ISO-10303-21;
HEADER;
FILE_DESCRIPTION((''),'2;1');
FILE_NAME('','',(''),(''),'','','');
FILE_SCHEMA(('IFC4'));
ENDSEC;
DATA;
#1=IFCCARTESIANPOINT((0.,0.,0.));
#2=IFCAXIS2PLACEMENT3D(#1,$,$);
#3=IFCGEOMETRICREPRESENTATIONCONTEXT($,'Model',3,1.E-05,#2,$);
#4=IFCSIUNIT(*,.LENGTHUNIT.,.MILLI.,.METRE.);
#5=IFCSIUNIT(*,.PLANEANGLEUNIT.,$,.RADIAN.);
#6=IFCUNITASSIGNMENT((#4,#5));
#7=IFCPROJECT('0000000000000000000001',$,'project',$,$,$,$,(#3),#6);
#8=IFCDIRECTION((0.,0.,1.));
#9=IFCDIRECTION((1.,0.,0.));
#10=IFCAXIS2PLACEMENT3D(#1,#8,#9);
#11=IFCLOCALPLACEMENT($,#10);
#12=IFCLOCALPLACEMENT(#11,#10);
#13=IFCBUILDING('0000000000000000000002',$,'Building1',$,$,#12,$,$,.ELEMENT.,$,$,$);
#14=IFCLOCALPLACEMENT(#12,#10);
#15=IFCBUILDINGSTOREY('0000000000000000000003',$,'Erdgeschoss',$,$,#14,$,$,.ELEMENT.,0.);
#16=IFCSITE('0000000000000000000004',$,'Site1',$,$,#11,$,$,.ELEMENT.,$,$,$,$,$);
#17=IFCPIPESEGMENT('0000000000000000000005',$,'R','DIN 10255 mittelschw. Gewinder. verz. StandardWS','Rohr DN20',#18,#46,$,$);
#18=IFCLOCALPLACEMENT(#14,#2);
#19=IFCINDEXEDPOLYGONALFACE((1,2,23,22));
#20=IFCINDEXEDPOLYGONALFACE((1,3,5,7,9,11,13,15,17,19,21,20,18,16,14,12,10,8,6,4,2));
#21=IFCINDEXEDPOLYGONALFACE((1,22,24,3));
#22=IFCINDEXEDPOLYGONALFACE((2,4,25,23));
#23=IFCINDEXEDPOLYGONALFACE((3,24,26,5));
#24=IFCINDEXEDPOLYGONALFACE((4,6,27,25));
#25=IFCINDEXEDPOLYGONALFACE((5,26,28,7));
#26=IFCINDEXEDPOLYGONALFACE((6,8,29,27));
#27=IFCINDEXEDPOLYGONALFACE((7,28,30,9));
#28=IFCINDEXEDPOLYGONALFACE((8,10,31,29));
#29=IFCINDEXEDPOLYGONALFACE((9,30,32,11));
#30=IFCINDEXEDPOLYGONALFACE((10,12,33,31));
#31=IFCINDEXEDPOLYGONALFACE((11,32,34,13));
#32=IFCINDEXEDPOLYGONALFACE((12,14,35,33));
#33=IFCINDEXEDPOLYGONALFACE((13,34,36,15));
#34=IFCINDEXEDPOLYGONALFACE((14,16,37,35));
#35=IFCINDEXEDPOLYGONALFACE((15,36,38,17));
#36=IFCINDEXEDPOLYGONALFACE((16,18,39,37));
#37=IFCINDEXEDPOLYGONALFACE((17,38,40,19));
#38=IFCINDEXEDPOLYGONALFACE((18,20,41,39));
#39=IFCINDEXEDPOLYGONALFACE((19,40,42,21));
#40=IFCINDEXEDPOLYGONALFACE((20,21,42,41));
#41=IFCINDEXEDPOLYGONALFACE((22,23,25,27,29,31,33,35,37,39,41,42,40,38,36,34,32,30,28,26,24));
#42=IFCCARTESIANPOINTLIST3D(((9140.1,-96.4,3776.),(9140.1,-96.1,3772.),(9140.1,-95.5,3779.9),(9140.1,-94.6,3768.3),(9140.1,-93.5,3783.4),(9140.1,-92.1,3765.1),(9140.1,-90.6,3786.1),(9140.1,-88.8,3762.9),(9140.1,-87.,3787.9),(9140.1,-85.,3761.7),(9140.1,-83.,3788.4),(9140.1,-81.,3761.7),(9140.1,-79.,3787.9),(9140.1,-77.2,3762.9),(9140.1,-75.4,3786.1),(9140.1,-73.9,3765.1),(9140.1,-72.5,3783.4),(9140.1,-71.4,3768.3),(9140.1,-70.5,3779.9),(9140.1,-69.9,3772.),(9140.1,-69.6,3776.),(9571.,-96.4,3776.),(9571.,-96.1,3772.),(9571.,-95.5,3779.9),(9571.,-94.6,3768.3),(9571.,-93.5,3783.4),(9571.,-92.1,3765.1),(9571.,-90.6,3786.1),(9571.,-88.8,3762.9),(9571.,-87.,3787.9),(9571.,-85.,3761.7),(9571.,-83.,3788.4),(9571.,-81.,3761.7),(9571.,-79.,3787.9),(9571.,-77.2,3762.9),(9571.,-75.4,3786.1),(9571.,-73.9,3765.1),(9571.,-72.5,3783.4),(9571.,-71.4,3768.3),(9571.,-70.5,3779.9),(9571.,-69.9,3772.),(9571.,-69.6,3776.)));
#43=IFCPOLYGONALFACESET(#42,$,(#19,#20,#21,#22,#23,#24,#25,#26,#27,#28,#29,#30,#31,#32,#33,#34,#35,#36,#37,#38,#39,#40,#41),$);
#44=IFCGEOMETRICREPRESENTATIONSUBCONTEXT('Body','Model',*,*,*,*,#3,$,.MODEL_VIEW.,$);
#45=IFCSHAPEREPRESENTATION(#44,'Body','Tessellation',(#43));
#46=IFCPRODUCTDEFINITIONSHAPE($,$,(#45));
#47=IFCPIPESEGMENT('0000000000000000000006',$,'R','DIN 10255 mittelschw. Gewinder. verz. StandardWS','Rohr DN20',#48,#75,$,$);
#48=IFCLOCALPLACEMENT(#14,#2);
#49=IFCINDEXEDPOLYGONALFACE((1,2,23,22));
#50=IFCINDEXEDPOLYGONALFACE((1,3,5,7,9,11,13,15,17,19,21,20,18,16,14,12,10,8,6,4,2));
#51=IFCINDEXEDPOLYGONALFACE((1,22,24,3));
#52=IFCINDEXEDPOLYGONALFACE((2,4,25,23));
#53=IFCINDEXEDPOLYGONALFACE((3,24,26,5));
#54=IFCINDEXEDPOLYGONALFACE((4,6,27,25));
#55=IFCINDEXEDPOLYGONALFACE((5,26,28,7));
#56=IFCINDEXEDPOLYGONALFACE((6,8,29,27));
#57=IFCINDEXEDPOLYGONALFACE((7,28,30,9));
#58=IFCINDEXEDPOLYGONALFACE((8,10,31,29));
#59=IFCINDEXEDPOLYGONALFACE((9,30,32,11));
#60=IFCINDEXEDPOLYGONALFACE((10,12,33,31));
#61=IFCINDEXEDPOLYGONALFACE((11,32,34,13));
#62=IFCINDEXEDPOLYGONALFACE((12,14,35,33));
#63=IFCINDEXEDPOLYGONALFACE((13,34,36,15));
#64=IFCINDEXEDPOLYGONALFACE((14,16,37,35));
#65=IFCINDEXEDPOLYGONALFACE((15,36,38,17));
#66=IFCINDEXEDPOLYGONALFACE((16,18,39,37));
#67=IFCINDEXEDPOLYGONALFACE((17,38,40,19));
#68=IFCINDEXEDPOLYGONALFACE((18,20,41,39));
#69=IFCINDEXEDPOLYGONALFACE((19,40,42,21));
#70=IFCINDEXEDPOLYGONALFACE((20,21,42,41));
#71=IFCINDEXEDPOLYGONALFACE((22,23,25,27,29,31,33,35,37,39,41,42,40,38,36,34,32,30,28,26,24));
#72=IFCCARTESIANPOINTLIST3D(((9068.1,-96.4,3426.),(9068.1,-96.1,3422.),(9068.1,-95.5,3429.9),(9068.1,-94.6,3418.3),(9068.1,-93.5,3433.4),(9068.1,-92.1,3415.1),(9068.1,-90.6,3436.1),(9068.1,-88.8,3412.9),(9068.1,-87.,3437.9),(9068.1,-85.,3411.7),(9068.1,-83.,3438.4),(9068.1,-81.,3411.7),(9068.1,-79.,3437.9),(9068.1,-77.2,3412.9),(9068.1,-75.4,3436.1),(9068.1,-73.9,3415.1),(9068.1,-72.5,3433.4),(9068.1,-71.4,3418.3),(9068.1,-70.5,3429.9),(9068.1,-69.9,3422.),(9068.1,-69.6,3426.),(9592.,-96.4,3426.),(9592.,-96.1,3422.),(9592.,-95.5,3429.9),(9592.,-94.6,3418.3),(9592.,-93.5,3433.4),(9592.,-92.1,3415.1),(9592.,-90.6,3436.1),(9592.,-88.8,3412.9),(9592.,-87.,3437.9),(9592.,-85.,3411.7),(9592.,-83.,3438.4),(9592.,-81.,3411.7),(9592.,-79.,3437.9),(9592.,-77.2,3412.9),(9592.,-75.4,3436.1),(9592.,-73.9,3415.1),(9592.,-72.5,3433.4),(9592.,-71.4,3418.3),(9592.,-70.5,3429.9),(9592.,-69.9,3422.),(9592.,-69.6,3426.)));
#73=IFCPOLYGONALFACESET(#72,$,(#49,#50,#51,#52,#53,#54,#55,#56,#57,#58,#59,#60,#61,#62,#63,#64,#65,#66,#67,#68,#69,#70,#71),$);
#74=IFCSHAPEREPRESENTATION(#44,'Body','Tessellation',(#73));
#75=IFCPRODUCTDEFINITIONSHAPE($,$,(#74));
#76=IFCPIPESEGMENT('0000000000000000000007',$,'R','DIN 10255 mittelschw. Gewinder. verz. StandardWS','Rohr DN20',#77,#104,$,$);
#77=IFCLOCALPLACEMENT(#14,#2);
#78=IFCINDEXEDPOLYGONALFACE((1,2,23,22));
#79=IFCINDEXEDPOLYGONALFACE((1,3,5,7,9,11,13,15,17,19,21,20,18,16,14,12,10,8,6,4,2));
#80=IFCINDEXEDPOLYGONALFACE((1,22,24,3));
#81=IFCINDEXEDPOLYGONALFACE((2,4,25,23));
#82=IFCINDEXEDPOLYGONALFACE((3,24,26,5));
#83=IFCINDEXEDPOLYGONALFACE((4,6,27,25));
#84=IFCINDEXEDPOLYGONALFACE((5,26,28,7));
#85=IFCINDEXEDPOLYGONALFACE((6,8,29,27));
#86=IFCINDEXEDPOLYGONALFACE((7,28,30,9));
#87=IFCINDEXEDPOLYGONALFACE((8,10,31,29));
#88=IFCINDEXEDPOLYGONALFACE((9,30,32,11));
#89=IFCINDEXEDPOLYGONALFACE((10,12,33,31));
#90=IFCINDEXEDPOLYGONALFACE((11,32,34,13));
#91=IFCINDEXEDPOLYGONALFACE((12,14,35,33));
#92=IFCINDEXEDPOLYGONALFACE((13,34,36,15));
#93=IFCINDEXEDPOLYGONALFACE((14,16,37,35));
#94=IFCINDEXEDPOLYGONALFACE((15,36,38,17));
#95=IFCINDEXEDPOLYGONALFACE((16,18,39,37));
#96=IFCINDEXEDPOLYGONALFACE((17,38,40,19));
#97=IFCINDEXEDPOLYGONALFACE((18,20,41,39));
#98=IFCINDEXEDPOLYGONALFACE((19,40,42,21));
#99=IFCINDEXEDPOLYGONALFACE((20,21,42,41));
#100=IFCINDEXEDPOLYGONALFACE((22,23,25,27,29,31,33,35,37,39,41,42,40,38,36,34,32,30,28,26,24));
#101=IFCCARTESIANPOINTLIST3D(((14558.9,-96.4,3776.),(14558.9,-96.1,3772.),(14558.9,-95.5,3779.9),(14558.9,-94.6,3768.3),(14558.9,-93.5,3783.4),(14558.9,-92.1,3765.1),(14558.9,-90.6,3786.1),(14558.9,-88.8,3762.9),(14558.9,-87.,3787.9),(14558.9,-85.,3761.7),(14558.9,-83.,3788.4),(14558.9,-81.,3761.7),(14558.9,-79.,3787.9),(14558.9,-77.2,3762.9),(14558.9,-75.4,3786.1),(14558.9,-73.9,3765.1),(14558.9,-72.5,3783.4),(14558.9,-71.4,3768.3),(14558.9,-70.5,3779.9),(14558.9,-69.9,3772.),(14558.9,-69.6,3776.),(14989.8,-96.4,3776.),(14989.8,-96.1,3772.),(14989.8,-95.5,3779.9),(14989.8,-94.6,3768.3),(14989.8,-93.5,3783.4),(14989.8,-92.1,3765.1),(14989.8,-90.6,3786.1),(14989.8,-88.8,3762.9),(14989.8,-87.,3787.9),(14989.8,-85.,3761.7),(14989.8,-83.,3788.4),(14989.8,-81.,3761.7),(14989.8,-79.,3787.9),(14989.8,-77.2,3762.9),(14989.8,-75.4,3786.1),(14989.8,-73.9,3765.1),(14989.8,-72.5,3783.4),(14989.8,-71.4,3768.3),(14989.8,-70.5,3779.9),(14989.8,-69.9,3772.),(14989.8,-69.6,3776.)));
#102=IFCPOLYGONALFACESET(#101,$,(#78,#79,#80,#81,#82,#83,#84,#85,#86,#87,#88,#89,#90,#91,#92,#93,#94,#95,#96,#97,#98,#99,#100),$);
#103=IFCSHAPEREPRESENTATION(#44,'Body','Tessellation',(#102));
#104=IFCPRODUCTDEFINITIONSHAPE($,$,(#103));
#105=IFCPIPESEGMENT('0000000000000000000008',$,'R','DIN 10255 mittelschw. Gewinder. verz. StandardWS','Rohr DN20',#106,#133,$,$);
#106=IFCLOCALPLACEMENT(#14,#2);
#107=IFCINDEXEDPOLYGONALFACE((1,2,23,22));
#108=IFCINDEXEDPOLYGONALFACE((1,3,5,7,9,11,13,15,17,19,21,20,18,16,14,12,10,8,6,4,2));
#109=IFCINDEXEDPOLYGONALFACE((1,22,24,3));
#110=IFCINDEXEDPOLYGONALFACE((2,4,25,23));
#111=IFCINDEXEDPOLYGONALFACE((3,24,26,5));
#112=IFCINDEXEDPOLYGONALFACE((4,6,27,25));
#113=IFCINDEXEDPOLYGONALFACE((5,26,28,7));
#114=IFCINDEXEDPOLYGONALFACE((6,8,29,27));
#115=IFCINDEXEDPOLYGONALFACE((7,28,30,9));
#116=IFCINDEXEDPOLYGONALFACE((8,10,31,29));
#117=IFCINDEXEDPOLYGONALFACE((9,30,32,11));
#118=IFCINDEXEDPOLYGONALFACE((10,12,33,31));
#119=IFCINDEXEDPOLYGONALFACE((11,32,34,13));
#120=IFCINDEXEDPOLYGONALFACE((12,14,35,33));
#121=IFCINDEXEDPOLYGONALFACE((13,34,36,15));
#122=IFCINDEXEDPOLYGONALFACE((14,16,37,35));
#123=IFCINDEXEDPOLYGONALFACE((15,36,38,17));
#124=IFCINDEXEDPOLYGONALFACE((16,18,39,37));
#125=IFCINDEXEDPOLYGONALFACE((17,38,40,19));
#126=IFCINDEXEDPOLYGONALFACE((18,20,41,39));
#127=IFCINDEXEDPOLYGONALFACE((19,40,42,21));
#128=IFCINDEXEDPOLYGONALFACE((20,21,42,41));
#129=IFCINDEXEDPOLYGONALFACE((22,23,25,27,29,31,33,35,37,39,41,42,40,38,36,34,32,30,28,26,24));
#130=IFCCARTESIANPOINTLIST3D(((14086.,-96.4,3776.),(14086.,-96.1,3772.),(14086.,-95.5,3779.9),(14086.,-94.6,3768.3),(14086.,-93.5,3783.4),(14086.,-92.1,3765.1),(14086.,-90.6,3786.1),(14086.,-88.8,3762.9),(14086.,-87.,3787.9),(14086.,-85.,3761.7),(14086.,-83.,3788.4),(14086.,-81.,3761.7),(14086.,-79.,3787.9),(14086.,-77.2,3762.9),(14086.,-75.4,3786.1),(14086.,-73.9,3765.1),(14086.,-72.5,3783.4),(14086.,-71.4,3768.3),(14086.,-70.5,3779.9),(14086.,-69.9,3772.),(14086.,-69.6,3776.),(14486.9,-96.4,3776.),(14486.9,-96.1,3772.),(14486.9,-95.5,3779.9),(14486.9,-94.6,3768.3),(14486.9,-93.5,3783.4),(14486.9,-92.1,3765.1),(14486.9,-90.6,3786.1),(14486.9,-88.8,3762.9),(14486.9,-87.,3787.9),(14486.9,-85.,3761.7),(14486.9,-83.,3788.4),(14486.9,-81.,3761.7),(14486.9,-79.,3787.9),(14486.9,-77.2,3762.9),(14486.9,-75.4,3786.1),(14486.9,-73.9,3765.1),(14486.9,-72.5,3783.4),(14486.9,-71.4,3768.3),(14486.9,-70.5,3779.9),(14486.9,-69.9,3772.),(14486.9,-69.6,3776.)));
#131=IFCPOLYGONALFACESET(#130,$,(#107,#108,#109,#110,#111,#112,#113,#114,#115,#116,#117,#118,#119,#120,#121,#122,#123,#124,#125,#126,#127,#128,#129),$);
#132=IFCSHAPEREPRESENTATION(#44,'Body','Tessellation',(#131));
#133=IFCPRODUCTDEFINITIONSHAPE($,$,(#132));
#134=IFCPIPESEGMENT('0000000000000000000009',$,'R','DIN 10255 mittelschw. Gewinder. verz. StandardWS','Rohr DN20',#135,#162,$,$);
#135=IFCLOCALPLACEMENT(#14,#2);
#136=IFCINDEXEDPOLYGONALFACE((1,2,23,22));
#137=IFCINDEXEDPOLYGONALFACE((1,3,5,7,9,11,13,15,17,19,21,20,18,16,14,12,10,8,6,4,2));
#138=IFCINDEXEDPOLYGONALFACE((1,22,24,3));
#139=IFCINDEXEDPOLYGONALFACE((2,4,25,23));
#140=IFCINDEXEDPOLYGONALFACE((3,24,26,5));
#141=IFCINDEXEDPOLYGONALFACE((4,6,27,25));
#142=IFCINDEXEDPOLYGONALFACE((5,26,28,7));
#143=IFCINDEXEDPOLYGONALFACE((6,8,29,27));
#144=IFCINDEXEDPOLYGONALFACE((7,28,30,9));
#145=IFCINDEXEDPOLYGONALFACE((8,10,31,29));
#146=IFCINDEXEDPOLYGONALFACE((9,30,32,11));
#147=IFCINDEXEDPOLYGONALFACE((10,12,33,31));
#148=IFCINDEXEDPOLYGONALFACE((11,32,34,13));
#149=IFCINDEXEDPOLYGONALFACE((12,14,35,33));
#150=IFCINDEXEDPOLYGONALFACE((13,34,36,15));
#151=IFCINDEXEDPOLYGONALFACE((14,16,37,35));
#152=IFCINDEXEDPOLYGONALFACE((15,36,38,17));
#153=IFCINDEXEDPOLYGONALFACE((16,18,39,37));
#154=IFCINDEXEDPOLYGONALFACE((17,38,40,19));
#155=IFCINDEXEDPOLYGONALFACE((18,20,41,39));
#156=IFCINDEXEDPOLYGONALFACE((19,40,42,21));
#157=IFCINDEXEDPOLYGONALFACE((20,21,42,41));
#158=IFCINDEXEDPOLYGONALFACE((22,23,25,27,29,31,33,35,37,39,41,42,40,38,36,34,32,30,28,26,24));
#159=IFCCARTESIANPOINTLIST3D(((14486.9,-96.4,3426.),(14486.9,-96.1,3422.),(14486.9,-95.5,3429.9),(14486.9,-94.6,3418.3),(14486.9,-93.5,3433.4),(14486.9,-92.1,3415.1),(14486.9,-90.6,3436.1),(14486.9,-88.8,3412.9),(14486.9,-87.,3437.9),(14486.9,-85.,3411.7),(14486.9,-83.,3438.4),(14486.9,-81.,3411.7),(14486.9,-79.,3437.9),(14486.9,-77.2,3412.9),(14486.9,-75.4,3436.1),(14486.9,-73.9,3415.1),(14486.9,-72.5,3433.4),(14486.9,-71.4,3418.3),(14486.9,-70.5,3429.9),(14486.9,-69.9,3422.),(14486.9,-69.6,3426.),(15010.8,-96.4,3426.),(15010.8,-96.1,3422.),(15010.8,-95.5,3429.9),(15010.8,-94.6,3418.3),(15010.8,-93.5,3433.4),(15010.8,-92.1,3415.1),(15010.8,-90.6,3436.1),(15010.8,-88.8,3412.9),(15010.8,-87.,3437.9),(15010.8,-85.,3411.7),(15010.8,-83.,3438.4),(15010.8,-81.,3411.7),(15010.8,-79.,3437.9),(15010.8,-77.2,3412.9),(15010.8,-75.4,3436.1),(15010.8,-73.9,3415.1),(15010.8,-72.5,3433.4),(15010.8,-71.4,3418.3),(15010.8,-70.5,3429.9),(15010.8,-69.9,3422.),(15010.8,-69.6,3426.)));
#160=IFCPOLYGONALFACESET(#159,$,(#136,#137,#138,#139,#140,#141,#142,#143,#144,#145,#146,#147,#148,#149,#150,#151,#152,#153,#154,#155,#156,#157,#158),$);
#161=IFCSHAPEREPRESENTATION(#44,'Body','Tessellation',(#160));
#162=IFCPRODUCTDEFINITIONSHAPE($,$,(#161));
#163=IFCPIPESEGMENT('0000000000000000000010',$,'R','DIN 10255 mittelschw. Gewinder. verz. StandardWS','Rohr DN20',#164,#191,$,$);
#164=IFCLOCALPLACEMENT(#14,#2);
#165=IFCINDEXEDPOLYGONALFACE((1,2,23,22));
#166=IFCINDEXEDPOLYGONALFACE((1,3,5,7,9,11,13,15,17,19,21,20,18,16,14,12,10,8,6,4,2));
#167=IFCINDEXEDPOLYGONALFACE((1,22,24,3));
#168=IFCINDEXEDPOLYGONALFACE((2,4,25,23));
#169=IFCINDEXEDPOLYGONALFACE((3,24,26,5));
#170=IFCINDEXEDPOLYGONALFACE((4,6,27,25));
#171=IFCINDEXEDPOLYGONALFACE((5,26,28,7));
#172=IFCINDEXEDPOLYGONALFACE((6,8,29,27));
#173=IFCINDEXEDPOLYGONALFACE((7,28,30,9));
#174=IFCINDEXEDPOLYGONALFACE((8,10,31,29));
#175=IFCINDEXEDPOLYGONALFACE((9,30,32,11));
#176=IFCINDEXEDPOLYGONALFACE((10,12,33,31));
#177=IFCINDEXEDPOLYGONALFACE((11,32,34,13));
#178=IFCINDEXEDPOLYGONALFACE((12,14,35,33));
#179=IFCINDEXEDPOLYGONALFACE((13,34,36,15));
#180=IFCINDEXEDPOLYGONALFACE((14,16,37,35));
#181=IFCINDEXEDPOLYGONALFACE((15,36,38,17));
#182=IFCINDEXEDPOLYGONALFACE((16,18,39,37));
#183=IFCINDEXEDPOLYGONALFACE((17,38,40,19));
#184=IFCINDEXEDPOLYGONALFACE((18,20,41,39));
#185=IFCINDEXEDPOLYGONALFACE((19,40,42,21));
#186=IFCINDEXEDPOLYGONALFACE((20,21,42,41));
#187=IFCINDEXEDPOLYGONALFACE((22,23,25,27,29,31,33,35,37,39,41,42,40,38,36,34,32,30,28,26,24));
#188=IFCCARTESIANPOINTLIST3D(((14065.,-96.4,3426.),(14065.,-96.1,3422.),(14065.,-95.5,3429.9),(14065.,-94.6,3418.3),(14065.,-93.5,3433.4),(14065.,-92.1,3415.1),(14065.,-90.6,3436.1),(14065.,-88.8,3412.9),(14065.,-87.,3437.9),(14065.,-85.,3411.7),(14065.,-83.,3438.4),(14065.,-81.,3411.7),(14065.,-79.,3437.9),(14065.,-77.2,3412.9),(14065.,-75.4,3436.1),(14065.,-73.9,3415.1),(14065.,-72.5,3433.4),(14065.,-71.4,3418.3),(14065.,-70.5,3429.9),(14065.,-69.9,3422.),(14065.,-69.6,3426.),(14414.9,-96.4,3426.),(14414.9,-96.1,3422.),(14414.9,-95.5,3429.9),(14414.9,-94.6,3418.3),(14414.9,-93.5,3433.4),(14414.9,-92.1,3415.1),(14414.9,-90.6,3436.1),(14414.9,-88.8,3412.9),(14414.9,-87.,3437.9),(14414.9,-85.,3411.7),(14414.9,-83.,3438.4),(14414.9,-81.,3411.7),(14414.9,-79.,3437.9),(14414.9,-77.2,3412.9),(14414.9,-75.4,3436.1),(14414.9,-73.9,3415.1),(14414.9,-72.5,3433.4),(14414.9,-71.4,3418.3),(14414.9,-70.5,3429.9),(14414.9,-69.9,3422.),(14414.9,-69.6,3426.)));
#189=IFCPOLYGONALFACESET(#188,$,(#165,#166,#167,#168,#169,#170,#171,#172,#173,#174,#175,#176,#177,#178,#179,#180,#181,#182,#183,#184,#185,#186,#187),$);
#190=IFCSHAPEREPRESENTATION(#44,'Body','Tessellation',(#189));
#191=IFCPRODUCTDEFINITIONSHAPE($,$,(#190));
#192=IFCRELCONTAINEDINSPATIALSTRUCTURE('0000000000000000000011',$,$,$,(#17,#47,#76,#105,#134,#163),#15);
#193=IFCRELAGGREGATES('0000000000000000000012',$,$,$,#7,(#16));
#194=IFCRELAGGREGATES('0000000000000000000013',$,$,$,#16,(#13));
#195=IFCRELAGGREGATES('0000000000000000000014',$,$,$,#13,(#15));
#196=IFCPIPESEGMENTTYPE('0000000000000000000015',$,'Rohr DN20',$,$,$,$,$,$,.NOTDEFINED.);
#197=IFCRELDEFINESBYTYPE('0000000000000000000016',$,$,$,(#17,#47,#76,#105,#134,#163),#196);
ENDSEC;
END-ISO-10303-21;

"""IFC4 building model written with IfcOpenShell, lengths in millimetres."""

from ifc_helpers import new_model, si_unit, frame, origin, origin_with_axes, origin_2d_with_axis, place, context, subcontext, project, spatial, circle, extrude, type_object, element, save


model = new_model("IFC4")

# Units and contexts
model_context = context("Model", 3, precision=1e-05, world=origin())
body_context = subcontext(model_context, "Body", "Model", "MODEL_VIEW")
ifc_project = project(units=[si_unit("LENGTHUNIT", "METRE", prefix="MILLI"), si_unit("PLANEANGLEUNIT", "RADIAN")], contexts=[model_context])

# Site, building, storey
site_placement = place(None, origin_with_axes())
site = spatial("IfcSite", under=ifc_project, at=site_placement, Name="Site1", CompositionType="ELEMENT")
building_placement = place(site_placement, origin_with_axes())
building = spatial("IfcBuilding", under=site, at=building_placement, Name="Building1", CompositionType="ELEMENT")
storey_placement = place(building_placement, origin_with_axes())
storey = spatial("IfcBuildingStorey", under=building, at=storey_placement, Name="Erdgeschoss", CompositionType="ELEMENT", Elevation=0.0)

# Pipe segments
pipe_segment_type_1 = type_object("IfcPipeSegmentType", Name="Rohr DN20", PredefinedType="NOTDEFINED")
pipe_segment_1_placement = place(storey_placement, frame((9355.6, -83.2, 3775.0), z_axis=(0.0, 0.0, 1.0), x_axis=(1.0, 0.0, 0.0)))
element("IfcPipeSegment", 1, at=pipe_segment_1_placement, inside=storey, type_object=pipe_segment_type_1, Name="R", Description="DIN 10255 mittelschw. Gewinder. verz. StandardWS", ObjectType="Rohr DN20", context=body_context, shape_type="SolidModel", body=[
    extrude(circle(Radius=13.4, at=origin_2d_with_axis()), frame((215.5, 0.2, 0.0), z_axis=(-1.0, 0.0, 0.0), x_axis=(0.0, 0.0, 1.0)), (0.0, 0.0, 1.0), 430.9),
])
pipe_segment_2_placement = place(storey_placement, frame((9330.1, -83.2, 3425.0), z_axis=(0.0, 0.0, 1.0), x_axis=(1.0, 0.0, 0.0)))
element("IfcPipeSegment", 2, at=pipe_segment_2_placement, inside=storey, type_object=pipe_segment_type_1, Name="R", Description="DIN 10255 mittelschw. Gewinder. verz. StandardWS", ObjectType="Rohr DN20", context=body_context, shape_type="SolidModel", body=[
    extrude(circle(Radius=13.4, at=origin_2d_with_axis()), frame((262.0, 0.2, 0.0), z_axis=(-1.0, 0.0, 0.0), x_axis=(0.0, 0.0, 1.0)), (0.0, 0.0, 1.0), 523.9),
])
pipe_segment_3_placement = place(storey_placement, frame((14774.4, -83.2, 3775.0), z_axis=(0.0, 0.0, 1.0), x_axis=(1.0, 0.0, 0.0)))
element("IfcPipeSegment", 3, at=pipe_segment_3_placement, inside=storey, type_object=pipe_segment_type_1, Name="R", Description="DIN 10255 mittelschw. Gewinder. verz. StandardWS", ObjectType="Rohr DN20", context=body_context, shape_type="SolidModel", body=[
    extrude(circle(Radius=13.4, at=origin_2d_with_axis()), frame((215.5, 0.2, 0.0), z_axis=(-1.0, 0.0, 0.0), x_axis=(0.0, 0.0, 1.0)), (0.0, 0.0, 1.0), 430.9),
])
pipe_segment_4_placement = place(storey_placement, frame((14286.5, -83.2, 3775.0), z_axis=(0.0, 0.0, 1.0), x_axis=(1.0, 0.0, 0.0)))
element("IfcPipeSegment", 4, at=pipe_segment_4_placement, inside=storey, type_object=pipe_segment_type_1, Name="R", Description="DIN 10255 mittelschw. Gewinder. verz. StandardWS", ObjectType="Rohr DN20", context=body_context, shape_type="SolidModel", body=[
    extrude(circle(Radius=13.4, at=origin_2d_with_axis()), frame((200.5, 0.1, 0.0), z_axis=(-1.0, 0.0, 0.0), x_axis=(0.0, 0.0, 1.0)), (0.0, 0.0, 1.0), 400.9),
])
pipe_segment_5_placement = place(storey_placement, frame((14748.9, -83.2, 3425.0), z_axis=(0.0, 0.0, 1.0), x_axis=(1.0, 0.0, 0.0)))
element("IfcPipeSegment", 5, at=pipe_segment_5_placement, inside=storey, type_object=pipe_segment_type_1, Name="R", Description="DIN 10255 mittelschw. Gewinder. verz. StandardWS", ObjectType="Rohr DN20", context=body_context, shape_type="SolidModel", body=[
    extrude(circle(Radius=13.4, at=origin_2d_with_axis()), frame((262.0, 0.2, 0.0), z_axis=(-1.0, 0.0, 0.0), x_axis=(0.0, 0.0, 1.0)), (0.0, 0.0, 1.0), 523.9),
])
pipe_segment_6_placement = place(storey_placement, frame((14240.0, -83.2, 3425.0), z_axis=(0.0, 0.0, 1.0), x_axis=(1.0, 0.0, 0.0)))
element("IfcPipeSegment", 6, at=pipe_segment_6_placement, inside=storey, type_object=pipe_segment_type_1, Name="R", Description="DIN 10255 mittelschw. Gewinder. verz. StandardWS", ObjectType="Rohr DN20", context=body_context, shape_type="SolidModel", body=[
    extrude(circle(Radius=13.4, at=origin_2d_with_axis()), frame((175.0, 0.2, 0.0), z_axis=(-1.0, 0.0, 0.0), x_axis=(0.0, 0.0, 1.0)), (0.0, 0.0, 1.0), 349.9),
])

save(model, "model.ifc")
